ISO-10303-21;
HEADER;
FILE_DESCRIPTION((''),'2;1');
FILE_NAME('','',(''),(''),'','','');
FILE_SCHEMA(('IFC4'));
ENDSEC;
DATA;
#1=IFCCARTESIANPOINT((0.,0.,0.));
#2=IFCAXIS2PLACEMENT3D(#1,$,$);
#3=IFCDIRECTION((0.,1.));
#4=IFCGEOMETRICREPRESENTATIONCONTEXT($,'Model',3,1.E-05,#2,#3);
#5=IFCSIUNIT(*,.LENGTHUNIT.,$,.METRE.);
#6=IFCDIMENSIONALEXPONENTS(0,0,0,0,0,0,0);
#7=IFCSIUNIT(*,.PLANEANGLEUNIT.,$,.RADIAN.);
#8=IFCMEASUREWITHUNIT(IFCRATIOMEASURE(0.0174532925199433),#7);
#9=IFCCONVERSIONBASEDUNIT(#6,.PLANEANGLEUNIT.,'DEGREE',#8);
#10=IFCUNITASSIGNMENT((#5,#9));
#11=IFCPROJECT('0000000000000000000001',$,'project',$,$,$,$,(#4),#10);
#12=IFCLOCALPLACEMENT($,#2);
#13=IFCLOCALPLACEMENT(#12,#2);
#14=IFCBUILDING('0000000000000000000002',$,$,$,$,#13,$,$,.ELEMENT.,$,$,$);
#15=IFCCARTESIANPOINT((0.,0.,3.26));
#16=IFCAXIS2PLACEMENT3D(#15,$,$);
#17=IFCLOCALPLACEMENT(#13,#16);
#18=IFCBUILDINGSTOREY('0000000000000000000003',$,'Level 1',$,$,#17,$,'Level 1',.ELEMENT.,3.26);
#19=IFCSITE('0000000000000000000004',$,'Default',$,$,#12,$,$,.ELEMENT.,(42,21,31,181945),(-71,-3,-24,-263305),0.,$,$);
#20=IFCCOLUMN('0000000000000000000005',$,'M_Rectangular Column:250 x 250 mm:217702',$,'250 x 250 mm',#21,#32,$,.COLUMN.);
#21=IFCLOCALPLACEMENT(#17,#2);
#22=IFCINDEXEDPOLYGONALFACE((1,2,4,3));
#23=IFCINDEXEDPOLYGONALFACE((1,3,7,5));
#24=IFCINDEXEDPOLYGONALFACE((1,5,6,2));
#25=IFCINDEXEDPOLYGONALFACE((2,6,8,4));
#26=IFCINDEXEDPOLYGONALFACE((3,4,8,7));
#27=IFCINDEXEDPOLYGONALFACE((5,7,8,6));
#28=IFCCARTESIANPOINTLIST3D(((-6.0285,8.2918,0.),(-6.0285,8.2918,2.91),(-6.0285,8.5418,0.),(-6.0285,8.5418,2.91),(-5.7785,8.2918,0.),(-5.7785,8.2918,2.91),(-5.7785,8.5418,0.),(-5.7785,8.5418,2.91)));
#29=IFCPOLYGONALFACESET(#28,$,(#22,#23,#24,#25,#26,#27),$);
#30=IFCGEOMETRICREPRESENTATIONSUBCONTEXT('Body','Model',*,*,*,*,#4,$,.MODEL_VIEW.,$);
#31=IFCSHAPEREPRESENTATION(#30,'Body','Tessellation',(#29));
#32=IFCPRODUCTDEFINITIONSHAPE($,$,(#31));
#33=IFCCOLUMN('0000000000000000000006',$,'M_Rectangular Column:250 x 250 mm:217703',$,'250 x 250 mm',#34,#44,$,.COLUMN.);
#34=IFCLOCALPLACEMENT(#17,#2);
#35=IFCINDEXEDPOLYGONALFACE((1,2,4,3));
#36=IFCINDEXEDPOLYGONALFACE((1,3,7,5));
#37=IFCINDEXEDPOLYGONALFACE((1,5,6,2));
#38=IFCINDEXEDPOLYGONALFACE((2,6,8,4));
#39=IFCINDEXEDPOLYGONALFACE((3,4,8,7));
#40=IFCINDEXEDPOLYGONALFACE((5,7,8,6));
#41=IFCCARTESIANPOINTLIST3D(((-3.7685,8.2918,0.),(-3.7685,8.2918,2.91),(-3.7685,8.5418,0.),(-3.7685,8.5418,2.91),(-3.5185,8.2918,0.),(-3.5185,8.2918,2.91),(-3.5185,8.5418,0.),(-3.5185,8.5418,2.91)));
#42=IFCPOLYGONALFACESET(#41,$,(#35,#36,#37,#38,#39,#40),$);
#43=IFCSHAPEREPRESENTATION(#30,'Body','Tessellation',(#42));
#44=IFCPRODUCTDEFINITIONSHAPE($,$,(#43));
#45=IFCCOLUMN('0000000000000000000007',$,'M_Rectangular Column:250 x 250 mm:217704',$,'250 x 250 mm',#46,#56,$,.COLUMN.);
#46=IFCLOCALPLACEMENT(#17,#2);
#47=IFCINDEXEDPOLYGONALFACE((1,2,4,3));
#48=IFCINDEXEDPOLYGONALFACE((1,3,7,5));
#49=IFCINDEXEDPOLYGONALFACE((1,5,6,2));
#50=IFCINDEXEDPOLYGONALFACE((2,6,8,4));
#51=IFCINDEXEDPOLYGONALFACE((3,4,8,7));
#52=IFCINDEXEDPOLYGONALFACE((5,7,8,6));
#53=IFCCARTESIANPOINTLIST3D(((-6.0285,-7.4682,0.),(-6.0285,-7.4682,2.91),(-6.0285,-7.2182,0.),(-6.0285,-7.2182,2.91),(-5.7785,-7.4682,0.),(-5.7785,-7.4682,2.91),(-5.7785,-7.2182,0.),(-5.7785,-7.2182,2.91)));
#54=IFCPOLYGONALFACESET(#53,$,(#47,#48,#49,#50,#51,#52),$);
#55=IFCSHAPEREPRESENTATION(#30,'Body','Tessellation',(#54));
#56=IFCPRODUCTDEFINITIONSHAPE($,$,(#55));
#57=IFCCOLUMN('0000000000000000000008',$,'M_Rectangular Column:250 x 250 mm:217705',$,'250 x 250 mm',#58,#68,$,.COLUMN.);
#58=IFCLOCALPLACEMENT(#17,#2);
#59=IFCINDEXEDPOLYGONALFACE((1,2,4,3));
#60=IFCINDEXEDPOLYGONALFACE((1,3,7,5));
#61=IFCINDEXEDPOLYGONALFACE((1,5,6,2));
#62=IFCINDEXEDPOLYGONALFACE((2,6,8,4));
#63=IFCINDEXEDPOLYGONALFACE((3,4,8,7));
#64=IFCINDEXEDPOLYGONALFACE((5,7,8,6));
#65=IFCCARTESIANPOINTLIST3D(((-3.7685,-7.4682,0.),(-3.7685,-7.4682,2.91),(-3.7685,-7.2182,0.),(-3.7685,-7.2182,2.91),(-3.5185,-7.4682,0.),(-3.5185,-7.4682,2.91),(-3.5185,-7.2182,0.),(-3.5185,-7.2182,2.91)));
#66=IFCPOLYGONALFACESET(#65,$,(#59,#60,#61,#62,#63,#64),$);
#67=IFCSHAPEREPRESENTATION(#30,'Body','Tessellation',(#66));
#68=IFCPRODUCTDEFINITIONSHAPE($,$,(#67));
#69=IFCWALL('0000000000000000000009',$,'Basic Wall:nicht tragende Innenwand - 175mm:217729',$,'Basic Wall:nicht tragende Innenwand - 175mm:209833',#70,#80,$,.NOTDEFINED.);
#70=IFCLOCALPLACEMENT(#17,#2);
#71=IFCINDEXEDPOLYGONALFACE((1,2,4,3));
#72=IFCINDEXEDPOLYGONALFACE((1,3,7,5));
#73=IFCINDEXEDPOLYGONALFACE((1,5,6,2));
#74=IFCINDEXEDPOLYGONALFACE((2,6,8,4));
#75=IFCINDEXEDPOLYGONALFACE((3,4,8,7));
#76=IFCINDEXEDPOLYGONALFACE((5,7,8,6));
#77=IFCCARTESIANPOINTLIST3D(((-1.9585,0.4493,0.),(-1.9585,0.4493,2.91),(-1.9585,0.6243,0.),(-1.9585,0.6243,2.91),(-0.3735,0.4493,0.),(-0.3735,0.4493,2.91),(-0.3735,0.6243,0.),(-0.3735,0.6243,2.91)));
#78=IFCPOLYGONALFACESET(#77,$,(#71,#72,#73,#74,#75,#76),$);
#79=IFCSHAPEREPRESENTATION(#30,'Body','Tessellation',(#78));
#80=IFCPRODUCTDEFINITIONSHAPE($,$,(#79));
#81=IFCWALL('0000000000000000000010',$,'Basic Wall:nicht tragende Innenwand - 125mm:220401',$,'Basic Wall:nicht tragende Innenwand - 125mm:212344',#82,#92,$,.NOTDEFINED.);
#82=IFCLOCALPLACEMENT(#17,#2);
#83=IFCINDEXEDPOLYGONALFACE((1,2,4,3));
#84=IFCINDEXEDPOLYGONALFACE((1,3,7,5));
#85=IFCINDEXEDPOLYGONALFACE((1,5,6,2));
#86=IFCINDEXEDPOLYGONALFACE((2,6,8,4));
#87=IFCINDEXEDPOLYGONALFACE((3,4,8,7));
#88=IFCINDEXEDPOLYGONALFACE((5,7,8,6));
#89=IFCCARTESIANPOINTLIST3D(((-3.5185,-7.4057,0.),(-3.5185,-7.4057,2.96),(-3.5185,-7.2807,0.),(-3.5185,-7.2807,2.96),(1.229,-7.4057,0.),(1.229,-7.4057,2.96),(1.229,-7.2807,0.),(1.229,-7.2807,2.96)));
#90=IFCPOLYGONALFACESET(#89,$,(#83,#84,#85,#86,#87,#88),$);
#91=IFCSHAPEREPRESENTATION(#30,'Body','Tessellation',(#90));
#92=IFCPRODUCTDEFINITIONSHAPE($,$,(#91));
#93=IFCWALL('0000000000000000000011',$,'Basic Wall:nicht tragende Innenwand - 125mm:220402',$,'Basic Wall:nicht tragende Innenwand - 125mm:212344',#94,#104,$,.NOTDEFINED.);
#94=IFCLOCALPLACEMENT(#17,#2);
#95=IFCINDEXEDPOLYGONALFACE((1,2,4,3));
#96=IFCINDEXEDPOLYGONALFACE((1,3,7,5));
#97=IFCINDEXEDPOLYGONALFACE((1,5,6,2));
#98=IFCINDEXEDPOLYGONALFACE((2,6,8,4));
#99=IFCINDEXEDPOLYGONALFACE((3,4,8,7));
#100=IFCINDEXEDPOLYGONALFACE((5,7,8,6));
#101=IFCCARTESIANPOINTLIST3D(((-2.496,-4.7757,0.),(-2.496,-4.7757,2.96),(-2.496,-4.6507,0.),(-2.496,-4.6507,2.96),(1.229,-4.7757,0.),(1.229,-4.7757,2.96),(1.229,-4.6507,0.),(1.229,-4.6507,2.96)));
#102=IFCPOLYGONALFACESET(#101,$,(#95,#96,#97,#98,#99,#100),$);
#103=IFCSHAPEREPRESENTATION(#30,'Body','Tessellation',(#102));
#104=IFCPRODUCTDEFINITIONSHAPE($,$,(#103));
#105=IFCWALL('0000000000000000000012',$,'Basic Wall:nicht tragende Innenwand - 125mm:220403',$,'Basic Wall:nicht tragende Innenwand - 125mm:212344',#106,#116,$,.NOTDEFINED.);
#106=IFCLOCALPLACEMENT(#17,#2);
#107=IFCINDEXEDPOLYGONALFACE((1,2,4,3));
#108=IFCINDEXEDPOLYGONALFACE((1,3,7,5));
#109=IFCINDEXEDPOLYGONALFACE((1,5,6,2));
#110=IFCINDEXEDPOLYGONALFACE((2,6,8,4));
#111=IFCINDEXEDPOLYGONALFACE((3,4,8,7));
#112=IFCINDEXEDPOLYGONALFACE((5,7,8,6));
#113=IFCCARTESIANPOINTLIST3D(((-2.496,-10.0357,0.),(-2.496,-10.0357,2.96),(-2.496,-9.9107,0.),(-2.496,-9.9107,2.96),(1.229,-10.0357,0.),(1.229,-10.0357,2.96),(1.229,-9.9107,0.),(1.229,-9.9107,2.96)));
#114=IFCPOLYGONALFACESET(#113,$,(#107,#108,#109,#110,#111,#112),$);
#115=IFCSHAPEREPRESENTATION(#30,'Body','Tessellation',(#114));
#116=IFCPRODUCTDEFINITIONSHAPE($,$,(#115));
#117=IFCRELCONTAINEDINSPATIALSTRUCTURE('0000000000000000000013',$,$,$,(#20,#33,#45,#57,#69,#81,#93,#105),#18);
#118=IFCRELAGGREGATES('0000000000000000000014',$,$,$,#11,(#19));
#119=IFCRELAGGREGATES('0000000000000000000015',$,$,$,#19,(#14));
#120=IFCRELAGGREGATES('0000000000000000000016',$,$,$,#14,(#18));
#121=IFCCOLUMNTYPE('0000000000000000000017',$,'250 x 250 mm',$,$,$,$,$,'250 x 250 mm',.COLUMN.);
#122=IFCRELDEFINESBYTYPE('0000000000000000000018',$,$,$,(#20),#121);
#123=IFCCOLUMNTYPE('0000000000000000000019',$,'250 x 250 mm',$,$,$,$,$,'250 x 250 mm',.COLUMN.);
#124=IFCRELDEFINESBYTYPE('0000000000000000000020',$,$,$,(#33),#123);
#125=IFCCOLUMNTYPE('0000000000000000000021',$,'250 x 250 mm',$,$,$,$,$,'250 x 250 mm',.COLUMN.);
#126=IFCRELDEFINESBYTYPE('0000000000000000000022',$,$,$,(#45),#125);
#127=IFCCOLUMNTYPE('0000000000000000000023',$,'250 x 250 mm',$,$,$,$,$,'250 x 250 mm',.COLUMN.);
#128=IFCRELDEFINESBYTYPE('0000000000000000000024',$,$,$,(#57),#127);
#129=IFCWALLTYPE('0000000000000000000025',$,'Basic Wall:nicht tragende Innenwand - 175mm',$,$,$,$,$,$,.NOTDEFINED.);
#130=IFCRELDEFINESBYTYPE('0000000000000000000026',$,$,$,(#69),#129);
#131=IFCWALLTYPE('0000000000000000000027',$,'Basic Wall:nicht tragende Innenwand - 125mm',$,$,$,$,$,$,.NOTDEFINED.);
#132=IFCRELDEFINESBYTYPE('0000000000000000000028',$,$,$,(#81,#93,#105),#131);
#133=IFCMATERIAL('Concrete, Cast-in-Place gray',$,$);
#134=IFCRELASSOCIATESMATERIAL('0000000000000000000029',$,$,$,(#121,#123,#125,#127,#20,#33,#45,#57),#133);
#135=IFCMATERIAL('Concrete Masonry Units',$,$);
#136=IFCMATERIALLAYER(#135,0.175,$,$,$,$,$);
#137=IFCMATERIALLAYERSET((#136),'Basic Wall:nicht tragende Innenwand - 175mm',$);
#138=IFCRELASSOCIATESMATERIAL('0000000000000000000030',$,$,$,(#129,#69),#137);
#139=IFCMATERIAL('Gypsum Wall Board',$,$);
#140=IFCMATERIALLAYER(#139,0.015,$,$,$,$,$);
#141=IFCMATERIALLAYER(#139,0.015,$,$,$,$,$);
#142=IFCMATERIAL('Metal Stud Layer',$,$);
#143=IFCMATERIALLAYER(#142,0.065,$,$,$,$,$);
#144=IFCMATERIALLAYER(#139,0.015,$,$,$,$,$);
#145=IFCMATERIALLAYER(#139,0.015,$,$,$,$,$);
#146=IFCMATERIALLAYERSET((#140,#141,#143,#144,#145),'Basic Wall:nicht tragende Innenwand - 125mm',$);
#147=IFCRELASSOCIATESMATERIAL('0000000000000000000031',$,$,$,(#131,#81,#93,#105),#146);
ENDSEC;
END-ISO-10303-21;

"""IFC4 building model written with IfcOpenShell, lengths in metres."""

from ifc_helpers import new_model, entity, si_unit, converted_unit, direction, frame, frame_2d, origin, place, context, subcontext, project, spatial, rectangle, extrude, source, transform, mapped, material, layer, layer_set, layer_usage, material_profile, profile_set, profile_usage, type_object, type_shapes, element, save


model = new_model("IFC4")

# Units and contexts
model_context = context("Model", 3, precision=1e-05, world=origin(), true_north=direction((0.0, 1.0)))
body_context = subcontext(model_context, "Body", "Model", "MODEL_VIEW")
ifc_project = project(units=[si_unit("LENGTHUNIT", "METRE"), converted_unit("PLANEANGLEUNIT", "DEGREE", entity("IfcRatioMeasure", 0.0174532925199433), si_unit("PLANEANGLEUNIT", "RADIAN"), dimensions=[0, 0, 0, 0, 0, 0, 0])], contexts=[model_context])

# Site, building, storey
site_placement = place(None, origin())
site = spatial("IfcSite", under=ifc_project, at=site_placement, Name="Default", CompositionType="ELEMENT", RefLatitude=(42, 21, 31, 181945), RefLongitude=(-71, -3, -24, -263305), RefElevation=0.0)
building_placement = place(site_placement, origin())
building = spatial("IfcBuilding", under=site, at=building_placement, CompositionType="ELEMENT")
storey_placement = place(building_placement, frame((0.0, 0.0, 3.26)))
storey = spatial("IfcBuildingStorey", under=building, at=storey_placement, Name="Level 1", LongName="Level 1", CompositionType="ELEMENT", Elevation=3.26)

# Columns
ifc_material_1 = material(Name="Concrete, Cast-in-Place gray")
ifc_material_profile = material_profile(ifc_material_1, rectangle(XDim=0.25, YDim=0.25, at=frame_2d((0.0, 0.0), x_axis=(1.0, 0.0))))
ifc_profile_set = profile_set([ifc_material_profile], Name="250 x 250 mm")
ifc_profile_usage_1 = profile_usage(ifc_profile_set)
column_type_1 = type_object("IfcColumnType", Name="250 x 250 mm", ElementType="250 x 250 mm", PredefinedType="COLUMN", material=ifc_profile_set)
shared_shape_1 = source(origin(), body_context, "Body", "SweptSolid", [
    extrude(rectangle(XDim=0.25, YDim=0.25, at=frame_2d((0.0, 0.0), x_axis=(1.0, 0.0))), frame((-5.9035, 8.4168, 3.26), z_axis=(0.0, 0.0, 1.0), x_axis=(0.0, -1.0, 0.0)), (0.0, 0.0, 1.0), 2.91),
])
type_shapes(column_type_1, [shared_shape_1])
column_1_placement = place(storey_placement, frame((0.0, 0.0, -3.26)))
element("IfcColumn", 1, at=column_1_placement, inside=storey, type_object=column_type_1, material=ifc_profile_usage_1, Name="M_Rectangular Column:250 x 250 mm:217702", ObjectType="250 x 250 mm", PredefinedType="COLUMN", context=body_context, shape_type="MappedRepresentation", body=[
    mapped(shared_shape_1, transform((0.0, 0.0, 0.0), scale=1.0)),
])
ifc_profile_usage_2 = profile_usage(ifc_profile_set)
column_type_2 = type_object("IfcColumnType", Name="250 x 250 mm", ElementType="250 x 250 mm", PredefinedType="COLUMN", material=ifc_profile_set)
shared_shape_2 = source(origin(), body_context, "Body", "SweptSolid", [
    extrude(rectangle(XDim=0.25, YDim=0.25, at=frame_2d((0.0, 0.0), x_axis=(1.0, 0.0))), frame((-3.6435, 8.4168, 3.26), z_axis=(0.0, 0.0, 1.0), x_axis=(0.0, -1.0, 0.0)), (0.0, 0.0, 1.0), 2.91),
])
type_shapes(column_type_2, [shared_shape_2])
column_2_placement = place(storey_placement, frame((0.0, 0.0, -3.26)))
element("IfcColumn", 2, at=column_2_placement, inside=storey, type_object=column_type_2, material=ifc_profile_usage_2, Name="M_Rectangular Column:250 x 250 mm:217703", ObjectType="250 x 250 mm", PredefinedType="COLUMN", context=body_context, shape_type="MappedRepresentation", body=[
    mapped(shared_shape_2, transform((0.0, 0.0, 0.0), scale=1.0)),
])
ifc_profile_usage_3 = profile_usage(ifc_profile_set)
column_type_3 = type_object("IfcColumnType", Name="250 x 250 mm", ElementType="250 x 250 mm", PredefinedType="COLUMN", material=ifc_profile_set)
shared_shape_3 = source(origin(), body_context, "Body", "SweptSolid", [
    extrude(rectangle(XDim=0.25, YDim=0.25, at=frame_2d((0.0, 0.0), x_axis=(1.0, 0.0))), frame((-5.9035, -7.3432, 3.26), z_axis=(0.0, 0.0, 1.0), x_axis=(0.0, -1.0, 0.0)), (0.0, 0.0, 1.0), 2.91),
])
type_shapes(column_type_3, [shared_shape_3])
column_3_placement = place(storey_placement, frame((0.0, 0.0, -3.26)))
element("IfcColumn", 3, at=column_3_placement, inside=storey, type_object=column_type_3, material=ifc_profile_usage_3, Name="M_Rectangular Column:250 x 250 mm:217704", ObjectType="250 x 250 mm", PredefinedType="COLUMN", context=body_context, shape_type="MappedRepresentation", body=[
    mapped(shared_shape_3, transform((0.0, 0.0, 0.0), scale=1.0)),
])
ifc_profile_usage_4 = profile_usage(ifc_profile_set)
column_type_4 = type_object("IfcColumnType", Name="250 x 250 mm", ElementType="250 x 250 mm", PredefinedType="COLUMN", material=ifc_profile_set)
shared_shape_4 = source(origin(), body_context, "Body", "SweptSolid", [
    extrude(rectangle(XDim=0.25, YDim=0.25, at=frame_2d((0.0, 0.0), x_axis=(1.0, 0.0))), frame((-3.6435, -7.3432, 3.26), z_axis=(0.0, 0.0, 1.0), x_axis=(0.0, -1.0, 0.0)), (0.0, 0.0, 1.0), 2.91),
])
type_shapes(column_type_4, [shared_shape_4])
column_4_placement = place(storey_placement, frame((0.0, 0.0, -3.26)))
element("IfcColumn", 4, at=column_4_placement, inside=storey, type_object=column_type_4, material=ifc_profile_usage_4, Name="M_Rectangular Column:250 x 250 mm:217705", ObjectType="250 x 250 mm", PredefinedType="COLUMN", context=body_context, shape_type="MappedRepresentation", body=[
    mapped(shared_shape_4, transform((0.0, 0.0, 0.0), scale=1.0)),
])

# Walls
ifc_material_2 = material(Name="Concrete Masonry Units")
ifc_layer_1 = layer(ifc_material_2, 0.175)
ifc_layer_set_1 = layer_set([ifc_layer_1], Name="Basic Wall:nicht tragende Innenwand - 175mm")
ifc_layer_usage_1 = layer_usage(ifc_layer_set_1, "AXIS2", "POSITIVE", -0.0875)
wall_type_1 = type_object("IfcWallType", Name="Basic Wall:nicht tragende Innenwand - 175mm", PredefinedType="NOTDEFINED", material=ifc_layer_set_1)
wall_1_placement = place(storey_placement, frame((-1.9585, 0.5368, 0.0)))
element("IfcWall", 5, at=wall_1_placement, inside=storey, type_object=wall_type_1, material=ifc_layer_usage_1, Name="Basic Wall:nicht tragende Innenwand - 175mm:217729", ObjectType="Basic Wall:nicht tragende Innenwand - 175mm:209833", PredefinedType="NOTDEFINED", context=body_context, shape_type="SweptSolid", body=[
    extrude(rectangle(XDim=1.585, YDim=0.175, at=frame_2d((0.7925, 0.0), x_axis=(-1.0, 0.0))), origin(), (0.0, 0.0, 1.0), 2.91),
])
ifc_material_3 = material(Name="Gypsum Wall Board")
ifc_layer_2 = layer(ifc_material_3, 0.015)
ifc_layer_3 = layer(ifc_material_3, 0.015)
ifc_material_4 = material(Name="Metal Stud Layer")
ifc_layer_4 = layer(ifc_material_4, 0.065)
ifc_layer_5 = layer(ifc_material_3, 0.015)
ifc_layer_6 = layer(ifc_material_3, 0.015)
ifc_layer_set_2 = layer_set([ifc_layer_2, ifc_layer_3, ifc_layer_4, ifc_layer_5, ifc_layer_6], Name="Basic Wall:nicht tragende Innenwand - 125mm")
ifc_layer_usage_2 = layer_usage(ifc_layer_set_2, "AXIS2", "POSITIVE", -0.0625)
wall_type_2 = type_object("IfcWallType", Name="Basic Wall:nicht tragende Innenwand - 125mm", PredefinedType="NOTDEFINED", material=ifc_layer_set_2)
wall_2_placement = place(storey_placement, frame((1.229, -7.3432, 0.0), z_axis=(0.0, 0.0, 1.0), x_axis=(-1.0, 0.0, 0.0)))
element("IfcWall", 6, at=wall_2_placement, inside=storey, type_object=wall_type_2, material=ifc_layer_usage_2, Name="Basic Wall:nicht tragende Innenwand - 125mm:220401", ObjectType="Basic Wall:nicht tragende Innenwand - 125mm:212344", PredefinedType="NOTDEFINED", context=body_context, shape_type="SweptSolid", body=[
    extrude(rectangle(XDim=4.7475, YDim=0.125, at=frame_2d((2.3737, 0.0), x_axis=(-1.0, 0.0))), origin(), (0.0, 0.0, 1.0), 2.96),
])
ifc_layer_usage_3 = layer_usage(ifc_layer_set_2, "AXIS2", "NEGATIVE", 0.0625)
wall_3_placement = place(storey_placement, frame((1.229, -4.7132, 0.0), z_axis=(0.0, 0.0, 1.0), x_axis=(-1.0, 0.0, 0.0)))
element("IfcWall", 7, at=wall_3_placement, inside=storey, type_object=wall_type_2, material=ifc_layer_usage_3, Name="Basic Wall:nicht tragende Innenwand - 125mm:220402", ObjectType="Basic Wall:nicht tragende Innenwand - 125mm:212344", PredefinedType="NOTDEFINED", context=body_context, shape_type="SweptSolid", body=[
    extrude(rectangle(XDim=3.725, YDim=0.125, at=frame_2d((1.8625, 0.0), x_axis=(-1.0, 0.0))), origin(), (0.0, 0.0, 1.0), 2.96),
])
ifc_layer_usage_4 = layer_usage(ifc_layer_set_2, "AXIS2", "POSITIVE", -0.0625)
wall_4_placement = place(storey_placement, frame((1.229, -9.9732, 0.0), z_axis=(0.0, 0.0, 1.0), x_axis=(-1.0, 0.0, 0.0)))
element("IfcWall", 8, at=wall_4_placement, inside=storey, type_object=wall_type_2, material=ifc_layer_usage_4, Name="Basic Wall:nicht tragende Innenwand - 125mm:220403", ObjectType="Basic Wall:nicht tragende Innenwand - 125mm:212344", PredefinedType="NOTDEFINED", context=body_context, shape_type="SweptSolid", body=[
    extrude(rectangle(XDim=3.725, YDim=0.125, at=frame_2d((1.8625, 0.0), x_axis=(-1.0, 0.0))), origin(), (0.0, 0.0, 1.0), 2.96),
])

save(model, "model.ifc")
